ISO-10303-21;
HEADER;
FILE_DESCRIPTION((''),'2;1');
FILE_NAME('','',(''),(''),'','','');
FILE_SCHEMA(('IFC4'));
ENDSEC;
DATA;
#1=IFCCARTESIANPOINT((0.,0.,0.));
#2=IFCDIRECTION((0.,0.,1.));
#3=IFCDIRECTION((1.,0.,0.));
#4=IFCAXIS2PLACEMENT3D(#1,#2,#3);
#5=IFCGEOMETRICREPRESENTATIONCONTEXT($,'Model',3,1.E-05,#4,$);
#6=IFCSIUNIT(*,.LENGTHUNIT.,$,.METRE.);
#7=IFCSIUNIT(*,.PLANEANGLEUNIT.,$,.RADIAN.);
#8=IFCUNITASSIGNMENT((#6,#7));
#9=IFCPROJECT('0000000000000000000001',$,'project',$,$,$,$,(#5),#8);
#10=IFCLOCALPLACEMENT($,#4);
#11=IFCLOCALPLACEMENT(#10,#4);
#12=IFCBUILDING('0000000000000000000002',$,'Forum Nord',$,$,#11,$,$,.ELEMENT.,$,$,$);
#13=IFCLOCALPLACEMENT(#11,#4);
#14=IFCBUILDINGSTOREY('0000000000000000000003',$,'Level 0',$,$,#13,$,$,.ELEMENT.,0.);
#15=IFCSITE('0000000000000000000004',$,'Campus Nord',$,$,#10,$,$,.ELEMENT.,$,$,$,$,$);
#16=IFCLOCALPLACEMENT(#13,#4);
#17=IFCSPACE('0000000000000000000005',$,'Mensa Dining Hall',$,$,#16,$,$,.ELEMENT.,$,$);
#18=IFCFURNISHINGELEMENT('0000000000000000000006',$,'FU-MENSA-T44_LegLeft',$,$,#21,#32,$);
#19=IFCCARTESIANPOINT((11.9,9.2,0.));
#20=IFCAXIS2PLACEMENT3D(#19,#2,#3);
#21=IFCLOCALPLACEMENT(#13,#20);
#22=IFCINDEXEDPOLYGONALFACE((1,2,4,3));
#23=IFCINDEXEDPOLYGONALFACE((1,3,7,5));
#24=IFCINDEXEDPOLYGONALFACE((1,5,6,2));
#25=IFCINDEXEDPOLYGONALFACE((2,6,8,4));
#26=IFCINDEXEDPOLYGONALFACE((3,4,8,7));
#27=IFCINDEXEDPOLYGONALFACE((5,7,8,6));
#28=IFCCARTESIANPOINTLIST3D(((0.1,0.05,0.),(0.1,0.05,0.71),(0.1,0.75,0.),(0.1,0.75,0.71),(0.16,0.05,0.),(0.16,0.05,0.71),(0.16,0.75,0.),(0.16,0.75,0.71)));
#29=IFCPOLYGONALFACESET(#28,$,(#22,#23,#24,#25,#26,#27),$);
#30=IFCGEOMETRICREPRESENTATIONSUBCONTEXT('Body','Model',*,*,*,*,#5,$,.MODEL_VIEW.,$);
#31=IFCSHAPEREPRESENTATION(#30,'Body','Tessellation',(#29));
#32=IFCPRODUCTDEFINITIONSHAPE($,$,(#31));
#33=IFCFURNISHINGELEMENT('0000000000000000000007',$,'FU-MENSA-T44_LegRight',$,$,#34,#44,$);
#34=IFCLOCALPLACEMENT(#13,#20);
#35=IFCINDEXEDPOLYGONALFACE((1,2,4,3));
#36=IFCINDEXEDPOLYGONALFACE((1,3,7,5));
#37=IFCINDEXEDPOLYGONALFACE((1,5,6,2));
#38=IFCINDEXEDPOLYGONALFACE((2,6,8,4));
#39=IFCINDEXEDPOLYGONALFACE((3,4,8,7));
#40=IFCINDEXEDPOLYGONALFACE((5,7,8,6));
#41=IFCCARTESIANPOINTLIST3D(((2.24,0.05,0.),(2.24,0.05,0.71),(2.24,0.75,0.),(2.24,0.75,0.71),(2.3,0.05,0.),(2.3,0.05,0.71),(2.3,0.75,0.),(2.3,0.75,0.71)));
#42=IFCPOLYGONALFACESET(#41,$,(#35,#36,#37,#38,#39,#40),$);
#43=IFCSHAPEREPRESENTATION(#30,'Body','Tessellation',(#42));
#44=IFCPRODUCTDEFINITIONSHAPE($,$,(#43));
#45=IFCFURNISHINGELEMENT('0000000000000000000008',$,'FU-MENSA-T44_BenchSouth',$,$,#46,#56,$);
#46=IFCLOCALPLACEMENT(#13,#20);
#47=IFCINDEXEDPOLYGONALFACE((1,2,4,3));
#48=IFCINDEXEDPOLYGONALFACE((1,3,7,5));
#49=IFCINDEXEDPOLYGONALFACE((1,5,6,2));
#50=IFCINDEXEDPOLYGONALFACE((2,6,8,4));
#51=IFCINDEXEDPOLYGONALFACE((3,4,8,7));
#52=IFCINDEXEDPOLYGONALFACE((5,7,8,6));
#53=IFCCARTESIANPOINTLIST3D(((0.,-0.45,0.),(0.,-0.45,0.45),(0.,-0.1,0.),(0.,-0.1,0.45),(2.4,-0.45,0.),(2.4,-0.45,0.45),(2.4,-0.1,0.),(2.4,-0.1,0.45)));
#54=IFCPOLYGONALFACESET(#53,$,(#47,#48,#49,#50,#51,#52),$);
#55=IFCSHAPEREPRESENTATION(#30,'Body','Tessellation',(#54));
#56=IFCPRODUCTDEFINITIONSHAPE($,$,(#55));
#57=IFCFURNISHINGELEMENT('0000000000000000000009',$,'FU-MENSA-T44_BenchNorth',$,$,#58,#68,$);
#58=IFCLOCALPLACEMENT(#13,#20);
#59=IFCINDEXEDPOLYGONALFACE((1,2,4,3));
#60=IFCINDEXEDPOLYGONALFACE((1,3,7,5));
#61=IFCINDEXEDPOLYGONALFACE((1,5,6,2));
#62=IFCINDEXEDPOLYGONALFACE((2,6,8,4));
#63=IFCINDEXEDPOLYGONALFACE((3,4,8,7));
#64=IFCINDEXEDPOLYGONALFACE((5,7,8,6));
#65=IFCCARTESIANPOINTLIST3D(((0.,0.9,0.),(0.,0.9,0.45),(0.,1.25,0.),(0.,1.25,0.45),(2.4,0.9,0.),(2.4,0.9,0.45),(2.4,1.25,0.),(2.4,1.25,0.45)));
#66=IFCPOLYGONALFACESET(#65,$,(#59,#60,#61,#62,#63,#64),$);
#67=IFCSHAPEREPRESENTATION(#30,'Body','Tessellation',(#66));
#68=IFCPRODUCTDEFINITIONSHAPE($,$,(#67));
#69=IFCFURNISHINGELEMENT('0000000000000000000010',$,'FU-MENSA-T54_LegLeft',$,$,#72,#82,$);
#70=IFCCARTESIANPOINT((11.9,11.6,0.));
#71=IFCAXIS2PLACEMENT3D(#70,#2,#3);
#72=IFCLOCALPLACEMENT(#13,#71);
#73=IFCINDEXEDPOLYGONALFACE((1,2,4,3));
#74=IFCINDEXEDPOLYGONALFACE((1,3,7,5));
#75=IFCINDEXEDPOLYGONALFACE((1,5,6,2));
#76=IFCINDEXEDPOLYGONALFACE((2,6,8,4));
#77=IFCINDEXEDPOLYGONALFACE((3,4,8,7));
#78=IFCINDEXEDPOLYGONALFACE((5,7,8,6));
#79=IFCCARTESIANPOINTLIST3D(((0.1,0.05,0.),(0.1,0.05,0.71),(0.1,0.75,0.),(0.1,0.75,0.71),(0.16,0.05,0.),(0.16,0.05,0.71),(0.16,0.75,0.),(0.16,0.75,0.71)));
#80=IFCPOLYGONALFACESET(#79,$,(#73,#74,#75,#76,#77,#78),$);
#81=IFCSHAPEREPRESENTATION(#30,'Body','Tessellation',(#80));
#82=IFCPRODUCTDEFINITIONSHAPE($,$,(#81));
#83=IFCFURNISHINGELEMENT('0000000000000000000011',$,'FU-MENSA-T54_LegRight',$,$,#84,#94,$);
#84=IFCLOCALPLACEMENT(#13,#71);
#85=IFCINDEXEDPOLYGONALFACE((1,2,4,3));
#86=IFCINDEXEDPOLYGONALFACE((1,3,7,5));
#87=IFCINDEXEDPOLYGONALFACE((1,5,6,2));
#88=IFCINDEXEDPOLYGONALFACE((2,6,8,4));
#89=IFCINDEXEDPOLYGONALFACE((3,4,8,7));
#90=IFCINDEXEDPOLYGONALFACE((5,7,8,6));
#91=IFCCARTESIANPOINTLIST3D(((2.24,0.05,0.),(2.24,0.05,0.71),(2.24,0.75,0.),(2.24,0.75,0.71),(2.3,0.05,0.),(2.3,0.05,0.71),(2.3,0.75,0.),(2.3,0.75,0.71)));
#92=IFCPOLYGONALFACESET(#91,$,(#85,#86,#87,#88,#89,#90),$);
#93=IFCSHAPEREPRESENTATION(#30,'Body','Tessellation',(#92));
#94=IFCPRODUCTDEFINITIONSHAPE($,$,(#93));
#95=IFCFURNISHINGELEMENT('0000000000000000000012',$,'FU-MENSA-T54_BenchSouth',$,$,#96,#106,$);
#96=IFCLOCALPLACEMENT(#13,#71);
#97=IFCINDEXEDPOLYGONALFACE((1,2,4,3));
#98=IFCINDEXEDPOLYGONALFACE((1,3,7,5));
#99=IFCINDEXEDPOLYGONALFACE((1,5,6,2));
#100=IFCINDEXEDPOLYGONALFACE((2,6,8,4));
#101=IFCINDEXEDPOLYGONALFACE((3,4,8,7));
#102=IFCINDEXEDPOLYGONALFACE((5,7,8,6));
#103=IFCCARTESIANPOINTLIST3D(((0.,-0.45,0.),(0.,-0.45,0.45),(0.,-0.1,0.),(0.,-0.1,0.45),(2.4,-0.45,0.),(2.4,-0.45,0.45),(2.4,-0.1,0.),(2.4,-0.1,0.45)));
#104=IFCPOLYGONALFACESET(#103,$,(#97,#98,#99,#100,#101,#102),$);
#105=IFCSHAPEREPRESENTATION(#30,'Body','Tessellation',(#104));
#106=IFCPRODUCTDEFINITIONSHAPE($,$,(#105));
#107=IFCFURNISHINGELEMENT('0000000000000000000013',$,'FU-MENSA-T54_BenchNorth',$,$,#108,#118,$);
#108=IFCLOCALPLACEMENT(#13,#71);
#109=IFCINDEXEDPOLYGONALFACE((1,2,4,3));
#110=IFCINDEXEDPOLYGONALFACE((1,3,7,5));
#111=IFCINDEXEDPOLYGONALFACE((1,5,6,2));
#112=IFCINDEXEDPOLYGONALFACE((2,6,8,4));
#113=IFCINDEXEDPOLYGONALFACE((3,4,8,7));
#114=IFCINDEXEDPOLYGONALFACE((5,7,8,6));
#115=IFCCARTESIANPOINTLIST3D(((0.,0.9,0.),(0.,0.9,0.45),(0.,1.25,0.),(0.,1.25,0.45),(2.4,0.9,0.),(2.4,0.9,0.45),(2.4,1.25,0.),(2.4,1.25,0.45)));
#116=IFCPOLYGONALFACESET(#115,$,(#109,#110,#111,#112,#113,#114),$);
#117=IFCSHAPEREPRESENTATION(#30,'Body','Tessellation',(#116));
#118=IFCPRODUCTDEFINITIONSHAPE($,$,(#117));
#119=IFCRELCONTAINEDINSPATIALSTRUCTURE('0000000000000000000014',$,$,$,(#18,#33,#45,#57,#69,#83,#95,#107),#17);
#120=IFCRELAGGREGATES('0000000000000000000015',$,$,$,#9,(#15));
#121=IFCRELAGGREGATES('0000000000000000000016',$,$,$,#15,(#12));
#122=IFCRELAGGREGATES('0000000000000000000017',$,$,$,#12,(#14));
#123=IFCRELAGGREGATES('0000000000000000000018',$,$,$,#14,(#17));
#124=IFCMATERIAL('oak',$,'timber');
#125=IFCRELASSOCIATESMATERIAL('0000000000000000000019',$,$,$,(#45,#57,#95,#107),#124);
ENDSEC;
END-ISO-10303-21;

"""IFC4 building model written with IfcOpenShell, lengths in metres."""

from ifc_helpers import new_model, si_unit, frame, frame_2d, origin_with_axes, place, context, subcontext, project, spatial, rectangle, extrude, material, element, save


model = new_model("IFC4")

# Units and contexts
model_context = context("Model", 3, precision=1e-05, world=origin_with_axes())
body_context = subcontext(model_context, "Body", "Model", "MODEL_VIEW")
ifc_project = project(units=[si_unit("LENGTHUNIT", "METRE"), si_unit("PLANEANGLEUNIT", "RADIAN")], contexts=[model_context])

# Site, building, storey
site_placement = place(None, origin_with_axes())
site = spatial("IfcSite", under=ifc_project, at=site_placement, Name="Campus Nord", CompositionType="ELEMENT")
building_placement = place(site_placement, origin_with_axes())
building = spatial("IfcBuilding", under=site, at=building_placement, Name="Forum Nord", CompositionType="ELEMENT")
storey_placement = place(building_placement, origin_with_axes())
storey = spatial("IfcBuildingStorey", under=building, at=storey_placement, Name="Level 0", CompositionType="ELEMENT", Elevation=0.0)

# Shared definitions
space_placement = place(storey_placement, origin_with_axes())
space = spatial("IfcSpace", under=storey, at=space_placement, Name="Mensa Dining Hall", CompositionType="ELEMENT")

# Furnishing elements
ifc_material_1 = material(Name="oak", Category="timber")
furnishing_1_placement = place(storey_placement, frame((11.9, 9.2, 0.0), z_axis=(0.0, 0.0, 1.0), x_axis=(1.0, 0.0, 0.0)))
element("IfcFurnishingElement", 1, at=furnishing_1_placement, inside=space, Name="FU-MENSA-T44_LegLeft", context=body_context, shape_type="SweptSolid", body=[
    extrude(rectangle(XDim=0.06, YDim=0.7, at=frame_2d((0.13, 0.4), x_axis=(1.0, 0.0))), origin_with_axes(), (0.0, 0.0, 1.0), 0.71),
])
furnishing_2_placement = place(storey_placement, frame((11.9, 9.2, 0.0), z_axis=(0.0, 0.0, 1.0), x_axis=(1.0, 0.0, 0.0)))
element("IfcFurnishingElement", 2, at=furnishing_2_placement, inside=space, Name="FU-MENSA-T44_LegRight", context=body_context, shape_type="SweptSolid", body=[
    extrude(rectangle(XDim=0.06, YDim=0.7, at=frame_2d((2.27, 0.4), x_axis=(1.0, 0.0))), origin_with_axes(), (0.0, 0.0, 1.0), 0.71),
])
furnishing_3_placement = place(storey_placement, frame((11.9, 9.2, 0.0), z_axis=(0.0, 0.0, 1.0), x_axis=(1.0, 0.0, 0.0)))
element("IfcFurnishingElement", 3, at=furnishing_3_placement, inside=space, material=ifc_material_1, Name="FU-MENSA-T44_BenchSouth", context=body_context, shape_type="SweptSolid", body=[
    extrude(rectangle(XDim=2.4, YDim=0.35, at=frame_2d((1.2, -0.275), x_axis=(1.0, 0.0))), origin_with_axes(), (0.0, 0.0, 1.0), 0.45),
])
furnishing_4_placement = place(storey_placement, frame((11.9, 9.2, 0.0), z_axis=(0.0, 0.0, 1.0), x_axis=(1.0, 0.0, 0.0)))
element("IfcFurnishingElement", 4, at=furnishing_4_placement, inside=space, material=ifc_material_1, Name="FU-MENSA-T44_BenchNorth", context=body_context, shape_type="SweptSolid", body=[
    extrude(rectangle(XDim=2.4, YDim=0.35, at=frame_2d((1.2, 1.075), x_axis=(1.0, 0.0))), origin_with_axes(), (0.0, 0.0, 1.0), 0.45),
])
furnishing_5_placement = place(storey_placement, frame((11.9, 11.6, 0.0), z_axis=(0.0, 0.0, 1.0), x_axis=(1.0, 0.0, 0.0)))
element("IfcFurnishingElement", 5, at=furnishing_5_placement, inside=space, Name="FU-MENSA-T54_LegLeft", context=body_context, shape_type="SweptSolid", body=[
    extrude(rectangle(XDim=0.06, YDim=0.7, at=frame_2d((0.13, 0.4), x_axis=(1.0, 0.0))), origin_with_axes(), (0.0, 0.0, 1.0), 0.71),
])
furnishing_6_placement = place(storey_placement, frame((11.9, 11.6, 0.0), z_axis=(0.0, 0.0, 1.0), x_axis=(1.0, 0.0, 0.0)))
element("IfcFurnishingElement", 6, at=furnishing_6_placement, inside=space, Name="FU-MENSA-T54_LegRight", context=body_context, shape_type="SweptSolid", body=[
    extrude(rectangle(XDim=0.06, YDim=0.7, at=frame_2d((2.27, 0.4), x_axis=(1.0, 0.0))), origin_with_axes(), (0.0, 0.0, 1.0), 0.71),
])
furnishing_7_placement = place(storey_placement, frame((11.9, 11.6, 0.0), z_axis=(0.0, 0.0, 1.0), x_axis=(1.0, 0.0, 0.0)))
element("IfcFurnishingElement", 7, at=furnishing_7_placement, inside=space, material=ifc_material_1, Name="FU-MENSA-T54_BenchSouth", context=body_context, shape_type="SweptSolid", body=[
    extrude(rectangle(XDim=2.4, YDim=0.35, at=frame_2d((1.2, -0.275), x_axis=(1.0, 0.0))), origin_with_axes(), (0.0, 0.0, 1.0), 0.45),
])
furnishing_8_placement = place(storey_placement, frame((11.9, 11.6, 0.0), z_axis=(0.0, 0.0, 1.0), x_axis=(1.0, 0.0, 0.0)))
element("IfcFurnishingElement", 8, at=furnishing_8_placement, inside=space, material=ifc_material_1, Name="FU-MENSA-T54_BenchNorth", context=body_context, shape_type="SweptSolid", body=[
    extrude(rectangle(XDim=2.4, YDim=0.35, at=frame_2d((1.2, 1.075), x_axis=(1.0, 0.0))), origin_with_axes(), (0.0, 0.0, 1.0), 0.45),
])

save(model, "model.ifc")
